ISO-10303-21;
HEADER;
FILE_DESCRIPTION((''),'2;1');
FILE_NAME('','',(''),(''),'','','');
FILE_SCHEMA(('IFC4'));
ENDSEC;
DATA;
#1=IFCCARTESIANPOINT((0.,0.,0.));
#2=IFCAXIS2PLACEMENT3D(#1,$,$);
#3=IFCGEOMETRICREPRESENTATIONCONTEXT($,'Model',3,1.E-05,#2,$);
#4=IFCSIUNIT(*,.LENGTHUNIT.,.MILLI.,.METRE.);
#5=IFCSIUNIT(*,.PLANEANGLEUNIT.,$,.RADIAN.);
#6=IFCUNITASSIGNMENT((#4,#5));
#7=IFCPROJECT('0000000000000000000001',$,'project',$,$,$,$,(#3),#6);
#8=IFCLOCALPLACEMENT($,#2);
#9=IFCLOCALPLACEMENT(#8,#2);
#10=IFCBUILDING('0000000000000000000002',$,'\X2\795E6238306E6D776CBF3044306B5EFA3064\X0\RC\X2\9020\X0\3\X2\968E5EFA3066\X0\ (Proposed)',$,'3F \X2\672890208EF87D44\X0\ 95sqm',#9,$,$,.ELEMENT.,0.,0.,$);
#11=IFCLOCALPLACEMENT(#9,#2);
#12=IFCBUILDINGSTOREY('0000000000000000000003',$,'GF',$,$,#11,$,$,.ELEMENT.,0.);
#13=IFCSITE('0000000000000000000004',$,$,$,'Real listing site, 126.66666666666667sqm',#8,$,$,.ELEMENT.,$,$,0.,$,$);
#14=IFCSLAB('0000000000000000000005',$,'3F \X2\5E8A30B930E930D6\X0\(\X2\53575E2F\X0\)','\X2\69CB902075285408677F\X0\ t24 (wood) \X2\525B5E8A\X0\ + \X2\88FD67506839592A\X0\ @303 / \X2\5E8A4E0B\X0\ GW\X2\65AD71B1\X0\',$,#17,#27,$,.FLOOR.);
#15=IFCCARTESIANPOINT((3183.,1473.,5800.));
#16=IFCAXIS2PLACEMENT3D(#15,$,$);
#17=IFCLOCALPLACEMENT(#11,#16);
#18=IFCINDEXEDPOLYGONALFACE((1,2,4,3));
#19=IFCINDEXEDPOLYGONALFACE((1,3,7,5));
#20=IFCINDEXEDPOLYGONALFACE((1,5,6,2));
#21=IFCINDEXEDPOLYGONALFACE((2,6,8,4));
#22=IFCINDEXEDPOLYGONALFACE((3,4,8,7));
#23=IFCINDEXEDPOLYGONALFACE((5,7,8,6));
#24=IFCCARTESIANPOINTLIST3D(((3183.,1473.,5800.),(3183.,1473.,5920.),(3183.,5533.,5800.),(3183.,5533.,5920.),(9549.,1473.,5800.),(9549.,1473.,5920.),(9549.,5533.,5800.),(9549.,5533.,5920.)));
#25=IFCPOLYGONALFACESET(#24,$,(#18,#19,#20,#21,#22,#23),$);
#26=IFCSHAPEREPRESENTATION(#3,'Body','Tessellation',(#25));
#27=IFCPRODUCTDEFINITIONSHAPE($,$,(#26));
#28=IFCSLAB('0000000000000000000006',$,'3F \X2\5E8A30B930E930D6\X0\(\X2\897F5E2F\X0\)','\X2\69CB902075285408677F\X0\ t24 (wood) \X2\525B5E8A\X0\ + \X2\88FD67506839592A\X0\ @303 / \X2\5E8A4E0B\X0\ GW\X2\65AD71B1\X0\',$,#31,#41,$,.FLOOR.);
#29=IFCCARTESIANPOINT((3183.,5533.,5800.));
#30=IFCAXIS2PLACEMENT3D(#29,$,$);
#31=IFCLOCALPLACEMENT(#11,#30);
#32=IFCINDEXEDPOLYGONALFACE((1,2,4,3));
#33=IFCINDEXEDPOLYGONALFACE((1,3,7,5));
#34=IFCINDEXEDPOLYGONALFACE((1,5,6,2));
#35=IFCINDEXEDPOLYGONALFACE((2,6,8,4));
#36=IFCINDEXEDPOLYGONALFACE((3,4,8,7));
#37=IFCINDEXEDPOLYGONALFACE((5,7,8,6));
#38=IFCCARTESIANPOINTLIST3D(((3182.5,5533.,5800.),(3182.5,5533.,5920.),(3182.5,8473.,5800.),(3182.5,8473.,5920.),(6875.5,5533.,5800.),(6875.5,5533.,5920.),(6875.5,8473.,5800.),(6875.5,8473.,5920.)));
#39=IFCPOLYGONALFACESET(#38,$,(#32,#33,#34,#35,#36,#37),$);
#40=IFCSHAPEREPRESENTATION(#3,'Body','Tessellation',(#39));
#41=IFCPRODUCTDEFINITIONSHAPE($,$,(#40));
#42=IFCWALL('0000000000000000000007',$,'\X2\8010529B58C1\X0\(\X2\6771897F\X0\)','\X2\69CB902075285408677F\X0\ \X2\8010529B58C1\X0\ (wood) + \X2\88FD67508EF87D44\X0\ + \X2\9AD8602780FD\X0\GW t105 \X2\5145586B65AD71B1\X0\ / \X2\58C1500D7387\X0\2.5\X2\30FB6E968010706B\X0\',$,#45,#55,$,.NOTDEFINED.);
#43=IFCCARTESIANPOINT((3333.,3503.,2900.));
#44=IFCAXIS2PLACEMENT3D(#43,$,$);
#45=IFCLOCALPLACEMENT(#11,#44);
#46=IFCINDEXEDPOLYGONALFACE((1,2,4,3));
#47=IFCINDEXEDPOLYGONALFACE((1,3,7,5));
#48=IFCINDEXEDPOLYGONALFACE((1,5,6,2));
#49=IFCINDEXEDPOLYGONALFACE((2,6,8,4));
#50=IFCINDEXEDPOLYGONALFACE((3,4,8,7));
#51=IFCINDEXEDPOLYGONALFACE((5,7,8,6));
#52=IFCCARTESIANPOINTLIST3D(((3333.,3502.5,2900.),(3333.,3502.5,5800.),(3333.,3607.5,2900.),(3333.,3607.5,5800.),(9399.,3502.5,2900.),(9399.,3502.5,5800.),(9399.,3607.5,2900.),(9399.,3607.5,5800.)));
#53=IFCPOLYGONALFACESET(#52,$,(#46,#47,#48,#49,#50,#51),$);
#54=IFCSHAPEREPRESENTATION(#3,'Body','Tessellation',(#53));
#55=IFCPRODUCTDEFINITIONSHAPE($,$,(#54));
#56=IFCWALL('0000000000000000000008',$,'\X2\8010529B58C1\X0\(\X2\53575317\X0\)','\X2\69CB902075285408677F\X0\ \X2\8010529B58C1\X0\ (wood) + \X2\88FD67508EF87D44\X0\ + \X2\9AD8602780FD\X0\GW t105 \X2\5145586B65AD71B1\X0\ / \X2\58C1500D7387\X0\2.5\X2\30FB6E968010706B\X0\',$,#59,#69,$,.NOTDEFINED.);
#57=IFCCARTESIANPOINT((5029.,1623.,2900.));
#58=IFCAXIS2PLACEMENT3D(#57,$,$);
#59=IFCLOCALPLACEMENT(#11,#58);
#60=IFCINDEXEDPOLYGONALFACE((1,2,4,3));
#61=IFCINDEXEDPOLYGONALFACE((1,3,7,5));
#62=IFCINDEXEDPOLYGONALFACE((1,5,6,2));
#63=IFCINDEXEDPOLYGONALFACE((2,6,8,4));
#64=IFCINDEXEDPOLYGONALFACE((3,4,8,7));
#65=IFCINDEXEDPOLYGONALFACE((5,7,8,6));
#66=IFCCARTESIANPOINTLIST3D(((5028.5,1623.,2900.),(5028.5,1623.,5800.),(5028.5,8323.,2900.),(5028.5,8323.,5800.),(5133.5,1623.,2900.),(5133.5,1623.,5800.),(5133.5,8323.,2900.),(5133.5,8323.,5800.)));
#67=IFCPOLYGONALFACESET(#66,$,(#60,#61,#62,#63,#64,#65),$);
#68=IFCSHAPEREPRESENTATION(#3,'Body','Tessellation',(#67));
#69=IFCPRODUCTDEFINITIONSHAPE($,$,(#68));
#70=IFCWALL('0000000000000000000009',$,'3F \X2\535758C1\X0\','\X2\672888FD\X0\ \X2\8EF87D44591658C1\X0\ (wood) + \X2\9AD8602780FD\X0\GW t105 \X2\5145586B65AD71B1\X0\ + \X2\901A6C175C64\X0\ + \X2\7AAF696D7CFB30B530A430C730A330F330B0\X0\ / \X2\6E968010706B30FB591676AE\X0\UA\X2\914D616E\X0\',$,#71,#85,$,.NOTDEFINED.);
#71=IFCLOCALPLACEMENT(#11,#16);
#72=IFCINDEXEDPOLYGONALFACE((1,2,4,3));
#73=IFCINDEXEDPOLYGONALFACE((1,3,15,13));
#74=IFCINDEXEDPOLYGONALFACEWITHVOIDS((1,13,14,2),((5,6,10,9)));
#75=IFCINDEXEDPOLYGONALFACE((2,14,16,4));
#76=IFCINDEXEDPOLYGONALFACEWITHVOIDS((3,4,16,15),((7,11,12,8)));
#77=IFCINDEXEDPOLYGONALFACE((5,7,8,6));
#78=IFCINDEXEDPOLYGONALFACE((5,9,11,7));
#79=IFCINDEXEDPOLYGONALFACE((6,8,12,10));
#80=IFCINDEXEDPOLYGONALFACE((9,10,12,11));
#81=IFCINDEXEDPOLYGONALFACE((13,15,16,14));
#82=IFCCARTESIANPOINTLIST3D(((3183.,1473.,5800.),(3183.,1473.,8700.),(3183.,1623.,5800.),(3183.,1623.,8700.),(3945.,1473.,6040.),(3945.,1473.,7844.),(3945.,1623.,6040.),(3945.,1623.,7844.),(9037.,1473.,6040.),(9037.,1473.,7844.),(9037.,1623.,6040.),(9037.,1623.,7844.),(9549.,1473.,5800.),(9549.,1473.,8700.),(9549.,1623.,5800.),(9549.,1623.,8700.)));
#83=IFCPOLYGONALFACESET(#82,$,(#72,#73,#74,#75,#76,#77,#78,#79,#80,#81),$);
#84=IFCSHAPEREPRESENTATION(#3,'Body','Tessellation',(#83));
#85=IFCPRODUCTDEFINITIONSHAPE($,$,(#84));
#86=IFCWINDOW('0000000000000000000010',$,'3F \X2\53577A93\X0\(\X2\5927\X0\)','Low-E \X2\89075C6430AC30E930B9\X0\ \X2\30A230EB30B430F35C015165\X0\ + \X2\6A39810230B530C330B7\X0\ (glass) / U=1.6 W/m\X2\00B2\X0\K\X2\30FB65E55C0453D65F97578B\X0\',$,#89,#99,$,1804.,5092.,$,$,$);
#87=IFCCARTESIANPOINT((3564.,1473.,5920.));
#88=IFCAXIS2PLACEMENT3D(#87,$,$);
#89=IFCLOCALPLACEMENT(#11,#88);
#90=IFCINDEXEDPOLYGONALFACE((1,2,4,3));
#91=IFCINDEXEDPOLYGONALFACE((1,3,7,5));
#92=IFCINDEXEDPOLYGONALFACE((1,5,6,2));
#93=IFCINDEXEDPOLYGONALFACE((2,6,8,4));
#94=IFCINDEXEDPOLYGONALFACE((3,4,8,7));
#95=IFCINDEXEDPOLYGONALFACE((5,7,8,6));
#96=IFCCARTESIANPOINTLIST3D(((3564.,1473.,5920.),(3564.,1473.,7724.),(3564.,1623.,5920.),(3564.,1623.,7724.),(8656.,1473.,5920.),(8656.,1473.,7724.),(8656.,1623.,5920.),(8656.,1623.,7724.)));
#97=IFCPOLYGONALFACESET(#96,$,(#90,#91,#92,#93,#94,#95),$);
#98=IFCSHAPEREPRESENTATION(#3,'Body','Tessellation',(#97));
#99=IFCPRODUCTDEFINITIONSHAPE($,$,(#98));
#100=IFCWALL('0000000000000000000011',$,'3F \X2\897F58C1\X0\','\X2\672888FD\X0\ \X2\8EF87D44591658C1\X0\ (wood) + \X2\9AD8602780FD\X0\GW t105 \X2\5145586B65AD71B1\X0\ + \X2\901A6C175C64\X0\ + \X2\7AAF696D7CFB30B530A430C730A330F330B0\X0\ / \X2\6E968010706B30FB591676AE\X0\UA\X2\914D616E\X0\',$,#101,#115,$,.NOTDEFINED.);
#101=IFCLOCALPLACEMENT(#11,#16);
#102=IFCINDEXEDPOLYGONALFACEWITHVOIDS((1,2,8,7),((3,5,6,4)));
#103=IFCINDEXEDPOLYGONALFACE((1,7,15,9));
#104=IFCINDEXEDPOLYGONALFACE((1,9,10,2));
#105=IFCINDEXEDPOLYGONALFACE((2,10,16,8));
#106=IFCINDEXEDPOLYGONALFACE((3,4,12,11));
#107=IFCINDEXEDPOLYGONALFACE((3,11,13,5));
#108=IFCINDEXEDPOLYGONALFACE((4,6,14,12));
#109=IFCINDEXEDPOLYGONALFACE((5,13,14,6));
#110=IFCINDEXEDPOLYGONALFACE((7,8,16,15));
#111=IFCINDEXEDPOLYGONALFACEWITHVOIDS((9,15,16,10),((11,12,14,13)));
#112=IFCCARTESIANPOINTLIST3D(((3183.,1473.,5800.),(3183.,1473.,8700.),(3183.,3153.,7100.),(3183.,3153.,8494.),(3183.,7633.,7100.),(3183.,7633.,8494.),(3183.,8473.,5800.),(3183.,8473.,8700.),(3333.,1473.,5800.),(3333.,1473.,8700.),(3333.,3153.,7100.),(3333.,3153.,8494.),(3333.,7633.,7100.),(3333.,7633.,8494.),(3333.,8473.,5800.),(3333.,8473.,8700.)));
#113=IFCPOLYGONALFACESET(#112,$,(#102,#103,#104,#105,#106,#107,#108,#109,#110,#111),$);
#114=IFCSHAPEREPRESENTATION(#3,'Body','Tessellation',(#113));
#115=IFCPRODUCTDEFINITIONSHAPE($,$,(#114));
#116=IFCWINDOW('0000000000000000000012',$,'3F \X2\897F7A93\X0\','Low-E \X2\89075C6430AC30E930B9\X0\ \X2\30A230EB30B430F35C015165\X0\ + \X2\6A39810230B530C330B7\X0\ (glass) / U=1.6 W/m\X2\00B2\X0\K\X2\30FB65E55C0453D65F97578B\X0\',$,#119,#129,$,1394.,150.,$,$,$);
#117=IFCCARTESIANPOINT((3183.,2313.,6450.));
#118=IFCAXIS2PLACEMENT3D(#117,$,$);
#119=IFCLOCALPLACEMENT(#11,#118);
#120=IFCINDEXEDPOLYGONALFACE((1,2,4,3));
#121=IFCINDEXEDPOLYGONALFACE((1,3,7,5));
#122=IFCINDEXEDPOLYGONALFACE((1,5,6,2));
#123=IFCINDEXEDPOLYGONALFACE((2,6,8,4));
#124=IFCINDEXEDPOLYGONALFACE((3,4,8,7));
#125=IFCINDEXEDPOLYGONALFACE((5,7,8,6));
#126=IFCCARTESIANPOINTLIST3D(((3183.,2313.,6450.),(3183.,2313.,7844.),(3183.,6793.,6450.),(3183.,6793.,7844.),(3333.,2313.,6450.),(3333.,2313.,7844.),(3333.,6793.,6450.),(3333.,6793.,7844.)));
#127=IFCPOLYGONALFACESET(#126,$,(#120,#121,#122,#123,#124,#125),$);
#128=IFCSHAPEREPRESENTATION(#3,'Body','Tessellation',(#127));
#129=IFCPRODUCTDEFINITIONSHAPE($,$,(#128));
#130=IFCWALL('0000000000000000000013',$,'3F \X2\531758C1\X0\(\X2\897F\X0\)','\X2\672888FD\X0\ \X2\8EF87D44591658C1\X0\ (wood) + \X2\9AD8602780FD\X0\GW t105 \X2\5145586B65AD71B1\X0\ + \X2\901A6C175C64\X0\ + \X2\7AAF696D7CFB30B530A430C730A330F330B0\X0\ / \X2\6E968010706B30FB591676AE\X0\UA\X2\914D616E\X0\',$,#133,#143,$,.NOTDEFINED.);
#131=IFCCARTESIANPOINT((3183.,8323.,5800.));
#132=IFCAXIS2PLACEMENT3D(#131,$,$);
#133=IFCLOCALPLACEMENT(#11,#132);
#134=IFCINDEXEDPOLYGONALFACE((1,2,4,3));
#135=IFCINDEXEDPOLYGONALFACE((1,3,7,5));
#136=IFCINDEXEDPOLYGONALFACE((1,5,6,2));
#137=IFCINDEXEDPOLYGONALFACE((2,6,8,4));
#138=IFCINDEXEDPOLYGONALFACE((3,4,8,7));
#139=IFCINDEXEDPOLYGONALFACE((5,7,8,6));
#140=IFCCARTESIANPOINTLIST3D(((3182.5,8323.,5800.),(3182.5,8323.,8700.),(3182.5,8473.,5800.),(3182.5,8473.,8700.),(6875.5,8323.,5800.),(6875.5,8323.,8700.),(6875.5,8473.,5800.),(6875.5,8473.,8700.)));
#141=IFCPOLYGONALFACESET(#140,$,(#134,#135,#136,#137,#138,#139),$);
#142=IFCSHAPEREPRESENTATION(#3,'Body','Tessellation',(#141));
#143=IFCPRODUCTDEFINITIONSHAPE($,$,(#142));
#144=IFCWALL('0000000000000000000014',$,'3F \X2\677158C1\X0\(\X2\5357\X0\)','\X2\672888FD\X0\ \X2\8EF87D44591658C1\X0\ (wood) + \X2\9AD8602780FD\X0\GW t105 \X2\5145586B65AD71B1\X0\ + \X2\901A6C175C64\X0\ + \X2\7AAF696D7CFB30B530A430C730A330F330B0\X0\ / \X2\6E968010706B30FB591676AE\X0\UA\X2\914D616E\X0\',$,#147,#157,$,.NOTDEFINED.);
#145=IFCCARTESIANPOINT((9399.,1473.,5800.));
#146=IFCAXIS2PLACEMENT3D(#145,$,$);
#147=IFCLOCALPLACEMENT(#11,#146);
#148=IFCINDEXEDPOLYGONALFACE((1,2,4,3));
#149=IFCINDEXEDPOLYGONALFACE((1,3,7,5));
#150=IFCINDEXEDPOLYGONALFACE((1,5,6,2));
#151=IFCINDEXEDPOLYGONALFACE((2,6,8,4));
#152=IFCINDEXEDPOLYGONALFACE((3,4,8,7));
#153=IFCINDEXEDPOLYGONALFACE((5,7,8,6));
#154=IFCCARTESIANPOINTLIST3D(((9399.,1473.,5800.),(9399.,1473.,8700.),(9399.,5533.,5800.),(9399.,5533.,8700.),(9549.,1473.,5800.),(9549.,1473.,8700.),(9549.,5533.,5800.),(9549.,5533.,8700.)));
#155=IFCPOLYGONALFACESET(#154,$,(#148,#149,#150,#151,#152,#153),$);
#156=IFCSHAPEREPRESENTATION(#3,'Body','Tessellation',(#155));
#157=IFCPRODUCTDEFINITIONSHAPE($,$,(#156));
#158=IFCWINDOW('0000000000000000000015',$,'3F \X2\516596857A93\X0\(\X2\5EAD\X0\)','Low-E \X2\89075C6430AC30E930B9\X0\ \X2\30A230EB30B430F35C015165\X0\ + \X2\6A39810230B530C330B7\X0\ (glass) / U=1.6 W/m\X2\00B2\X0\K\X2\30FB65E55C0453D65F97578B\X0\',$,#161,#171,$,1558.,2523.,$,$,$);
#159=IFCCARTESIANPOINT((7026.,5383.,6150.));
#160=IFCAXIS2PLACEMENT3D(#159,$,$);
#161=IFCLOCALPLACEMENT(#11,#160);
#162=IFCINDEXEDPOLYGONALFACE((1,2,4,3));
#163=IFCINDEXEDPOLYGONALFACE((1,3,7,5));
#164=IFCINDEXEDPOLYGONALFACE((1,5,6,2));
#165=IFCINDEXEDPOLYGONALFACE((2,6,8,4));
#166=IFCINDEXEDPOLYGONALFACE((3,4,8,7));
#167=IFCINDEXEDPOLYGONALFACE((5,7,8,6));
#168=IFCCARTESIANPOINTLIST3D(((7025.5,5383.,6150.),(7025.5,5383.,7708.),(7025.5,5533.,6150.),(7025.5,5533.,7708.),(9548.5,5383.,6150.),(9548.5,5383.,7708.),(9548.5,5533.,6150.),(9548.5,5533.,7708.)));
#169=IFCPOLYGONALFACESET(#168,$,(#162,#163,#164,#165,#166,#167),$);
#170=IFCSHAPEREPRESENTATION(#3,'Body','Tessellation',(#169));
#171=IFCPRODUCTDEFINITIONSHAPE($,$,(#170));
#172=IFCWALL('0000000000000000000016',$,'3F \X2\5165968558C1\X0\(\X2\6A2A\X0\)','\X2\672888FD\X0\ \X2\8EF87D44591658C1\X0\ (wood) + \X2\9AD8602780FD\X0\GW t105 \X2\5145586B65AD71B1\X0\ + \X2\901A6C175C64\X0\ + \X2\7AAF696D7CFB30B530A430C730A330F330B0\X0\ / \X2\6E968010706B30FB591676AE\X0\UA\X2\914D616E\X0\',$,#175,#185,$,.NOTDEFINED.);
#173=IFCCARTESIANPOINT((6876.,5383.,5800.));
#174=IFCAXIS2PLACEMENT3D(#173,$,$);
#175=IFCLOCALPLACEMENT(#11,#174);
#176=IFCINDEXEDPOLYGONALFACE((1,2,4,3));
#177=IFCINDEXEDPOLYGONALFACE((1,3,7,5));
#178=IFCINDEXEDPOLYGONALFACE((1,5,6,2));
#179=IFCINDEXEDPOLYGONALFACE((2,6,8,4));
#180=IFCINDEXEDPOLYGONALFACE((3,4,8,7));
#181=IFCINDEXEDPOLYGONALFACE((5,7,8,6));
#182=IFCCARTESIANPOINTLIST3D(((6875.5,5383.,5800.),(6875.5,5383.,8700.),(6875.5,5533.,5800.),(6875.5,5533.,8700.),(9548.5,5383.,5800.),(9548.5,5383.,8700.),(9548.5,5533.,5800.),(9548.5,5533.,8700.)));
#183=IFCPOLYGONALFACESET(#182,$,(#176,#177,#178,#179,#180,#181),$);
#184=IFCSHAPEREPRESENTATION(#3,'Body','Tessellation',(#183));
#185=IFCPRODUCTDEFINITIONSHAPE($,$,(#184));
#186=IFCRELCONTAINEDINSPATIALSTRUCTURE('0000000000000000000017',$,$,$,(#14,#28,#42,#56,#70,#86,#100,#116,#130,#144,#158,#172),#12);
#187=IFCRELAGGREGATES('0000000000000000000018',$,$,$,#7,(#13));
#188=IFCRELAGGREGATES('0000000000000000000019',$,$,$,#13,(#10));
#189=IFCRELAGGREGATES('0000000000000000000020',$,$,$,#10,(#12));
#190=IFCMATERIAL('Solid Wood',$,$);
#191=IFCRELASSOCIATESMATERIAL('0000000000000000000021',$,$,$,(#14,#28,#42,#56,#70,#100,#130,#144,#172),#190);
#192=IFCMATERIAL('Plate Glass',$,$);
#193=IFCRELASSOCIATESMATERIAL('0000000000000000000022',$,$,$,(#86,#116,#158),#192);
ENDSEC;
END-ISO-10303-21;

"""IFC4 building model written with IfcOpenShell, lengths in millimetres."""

from ifc_helpers import new_model, si_unit, frame, frame_2d, origin, place, context, project, spatial, rectangle, extrude, material, element, fill, save


model = new_model("IFC4")

# Units and contexts
model_context = context("Model", 3, precision=1e-05, world=origin())
ifc_project = project(units=[si_unit("LENGTHUNIT", "METRE", prefix="MILLI"), si_unit("PLANEANGLEUNIT", "RADIAN")], contexts=[model_context])

# Site, building, storey
site_placement = place(None, origin())
site = spatial("IfcSite", under=ifc_project, at=site_placement, ObjectType="Real listing site, 126.66666666666667sqm", CompositionType="ELEMENT", RefElevation=0.0)
building_placement = place(site_placement, origin())
building = spatial("IfcBuilding", under=site, at=building_placement, Name="神戸の海沿いに建つRC造3階建て (Proposed)", ObjectType="3F 木造軸組 95sqm", CompositionType="ELEMENT", ElevationOfRefHeight=0.0, ElevationOfTerrain=0.0)
storey_placement = place(building_placement, origin())
storey = spatial("IfcBuildingStorey", under=building, at=storey_placement, Name="GF", CompositionType="ELEMENT", Elevation=0.0)

# Slabs
ifc_material_1 = material(Name="Solid Wood")
slab_1_placement = place(storey_placement, frame((3183.0, 1473.0, 5800.0)))
element("IfcSlab", 1, at=slab_1_placement, inside=storey, material=ifc_material_1, Name="3F 床スラブ(南帯)", Description="構造用合板 t24 (wood) 剛床 + 製材根太 @303 / 床下 GW断熱", PredefinedType="FLOOR", context=model_context, shape_type="SweptSolid", body=[
    extrude(rectangle(XDim=6366.0, YDim=4060.0, at=frame_2d((3183.0, 2030.0))), frame((3183.0, 1473.0, 5800.0)), (0.0, 0.0, 1.0), 120.0),
])
slab_2_placement = place(storey_placement, frame((3183.0, 5533.0, 5800.0)))
element("IfcSlab", 2, at=slab_2_placement, inside=storey, material=ifc_material_1, Name="3F 床スラブ(西帯)", Description="構造用合板 t24 (wood) 剛床 + 製材根太 @303 / 床下 GW断熱", PredefinedType="FLOOR", context=model_context, shape_type="SweptSolid", body=[
    extrude(rectangle(XDim=3693.0, YDim=2940.0, at=frame_2d((1846.0, 1470.0))), frame((3183.0, 5533.0, 5800.0)), (0.0, 0.0, 1.0), 120.0),
])

# Walls
wall_1_placement = place(storey_placement, frame((3333.0, 3503.0, 2900.0)))
element("IfcWall", 3, at=wall_1_placement, inside=storey, material=ifc_material_1, Name="耐力壁(東西)", Description="構造用合板 耐力壁 (wood) + 製材軸組 + 高性能GW t105 充填断熱 / 壁倍率2.5・準耐火", PredefinedType="NOTDEFINED", context=model_context, shape_type="SweptSolid", body=[
    extrude(rectangle(XDim=6066.0, YDim=105.0, at=frame_2d((3033.0, 52.0))), frame((3333.0, 3503.0, 2900.0)), (0.0, 0.0, 1.0), 2900.0),
])
wall_2_placement = place(storey_placement, frame((5029.0, 1623.0, 2900.0)))
element("IfcWall", 4, at=wall_2_placement, inside=storey, material=ifc_material_1, Name="耐力壁(南北)", Description="構造用合板 耐力壁 (wood) + 製材軸組 + 高性能GW t105 充填断熱 / 壁倍率2.5・準耐火", PredefinedType="NOTDEFINED", context=model_context, shape_type="SweptSolid", body=[
    extrude(rectangle(XDim=105.0, YDim=6700.0, at=frame_2d((52.0, 3350.0))), frame((5029.0, 1623.0, 2900.0)), (0.0, 0.0, 1.0), 2900.0),
])

# Walls, openings, windows
wall_3_placement = place(storey_placement, frame((3183.0, 1473.0, 5800.0)))
wall_3 = element("IfcWall", 5, at=wall_3_placement, inside=storey, material=ifc_material_1, Name="3F 南壁", Description="木製 軸組外壁 (wood) + 高性能GW t105 充填断熱 + 通気層 + 窯業系サイディング / 準耐火・外皮UA配慮", PredefinedType="NOTDEFINED", context=model_context, shape_type="SweptSolid", body=[
    extrude(rectangle(XDim=6366.0, YDim=150.0, at=frame_2d((3183.0, 75.0))), frame((3183.0, 1473.0, 5800.0)), (0.0, 0.0, 1.0), 2900.0),
])
opening_1_placement = place(storey_placement, frame((3564.0, 1473.0, 5920.0)))
opening_1 = element("IfcOpeningElement", 6, at=opening_1_placement, cuts=wall_3, PredefinedType="NOTDEFINED", context=model_context, shape_type="SweptSolid", body=[
    extrude(rectangle(XDim=5092.0, YDim=150.0, at=frame_2d((2546.0, 75.0))), frame((3564.0, 1473.0, 5920.0)), (0.0, 0.0, 1.0), 1804.0),
])
ifc_material_2 = material(Name="Plate Glass")
window_1_placement = place(storey_placement, frame((3564.0, 1473.0, 5920.0)))
window_1 = element("IfcWindow", 7, at=window_1_placement, inside=storey, material=ifc_material_2, Name="3F 南窓(大)", Description="Low-E 複層ガラス アルゴン封入 + 樹脂サッシ (glass) / U=1.6 W/m²K・日射取得型", OverallHeight=1804.0, OverallWidth=5092.0, context=model_context, shape_type="SweptSolid", body=[
    extrude(rectangle(XDim=5092.0, YDim=150.0, at=frame_2d((2546.0, 75.0))), frame((3564.0, 1473.0, 5920.0)), (0.0, 0.0, 1.0), 1804.0),
])
fill(opening_1, window_1)
wall_4_placement = place(storey_placement, frame((3183.0, 1473.0, 5800.0)))
wall_4 = element("IfcWall", 8, at=wall_4_placement, inside=storey, material=ifc_material_1, Name="3F 西壁", Description="木製 軸組外壁 (wood) + 高性能GW t105 充填断熱 + 通気層 + 窯業系サイディング / 準耐火・外皮UA配慮", PredefinedType="NOTDEFINED", context=model_context, shape_type="SweptSolid", body=[
    extrude(rectangle(XDim=150.0, YDim=7000.0, at=frame_2d((75.0, 3500.0))), frame((3183.0, 1473.0, 5800.0)), (0.0, 0.0, 1.0), 2900.0),
])
opening_2_placement = place(storey_placement, frame((3183.0, 2313.0, 6450.0)))
opening_2 = element("IfcOpeningElement", 9, at=opening_2_placement, cuts=wall_4, PredefinedType="NOTDEFINED", context=model_context, shape_type="SweptSolid", body=[
    extrude(rectangle(XDim=150.0, YDim=4480.0, at=frame_2d((75.0, 2240.0))), frame((3183.0, 2313.0, 6450.0)), (0.0, 0.0, 1.0), 1394.0),
])
window_2_placement = place(storey_placement, frame((3183.0, 2313.0, 6450.0)))
window_2 = element("IfcWindow", 10, at=window_2_placement, inside=storey, material=ifc_material_2, Name="3F 西窓", Description="Low-E 複層ガラス アルゴン封入 + 樹脂サッシ (glass) / U=1.6 W/m²K・日射取得型", OverallHeight=1394.0, OverallWidth=150.0, context=model_context, shape_type="SweptSolid", body=[
    extrude(rectangle(XDim=150.0, YDim=4480.0, at=frame_2d((75.0, 2240.0))), frame((3183.0, 2313.0, 6450.0)), (0.0, 0.0, 1.0), 1394.0),
])
fill(opening_2, window_2)

# Wall
wall_5_placement = place(storey_placement, frame((3183.0, 8323.0, 5800.0)))
element("IfcWall", 11, at=wall_5_placement, inside=storey, material=ifc_material_1, Name="3F 北壁(西)", Description="木製 軸組外壁 (wood) + 高性能GW t105 充填断熱 + 通気層 + 窯業系サイディング / 準耐火・外皮UA配慮", PredefinedType="NOTDEFINED", context=model_context, shape_type="SweptSolid", body=[
    extrude(rectangle(XDim=3693.0, YDim=150.0, at=frame_2d((1846.0, 75.0))), frame((3183.0, 8323.0, 5800.0)), (0.0, 0.0, 1.0), 2900.0),
])

# Wall, opening, window
wall_6_placement = place(storey_placement, frame((9399.0, 1473.0, 5800.0)))
wall_6 = element("IfcWall", 12, at=wall_6_placement, inside=storey, material=ifc_material_1, Name="3F 東壁(南)", Description="木製 軸組外壁 (wood) + 高性能GW t105 充填断熱 + 通気層 + 窯業系サイディング / 準耐火・外皮UA配慮", PredefinedType="NOTDEFINED", context=model_context, shape_type="SweptSolid", body=[
    extrude(rectangle(XDim=150.0, YDim=4060.0, at=frame_2d((75.0, 2030.0))), frame((9399.0, 1473.0, 5800.0)), (0.0, 0.0, 1.0), 2900.0),
])
opening_3_placement = place(storey_placement, frame((7026.0, 5383.0, 6150.0)))
opening_3 = element("IfcOpeningElement", 13, at=opening_3_placement, cuts=wall_6, PredefinedType="NOTDEFINED", context=model_context, shape_type="SweptSolid", body=[
    extrude(rectangle(XDim=2523.0, YDim=150.0, at=frame_2d((1261.0, 75.0))), frame((7026.0, 5383.0, 6150.0)), (0.0, 0.0, 1.0), 1558.0),
])
window_3_placement = place(storey_placement, frame((7026.0, 5383.0, 6150.0)))
window_3 = element("IfcWindow", 14, at=window_3_placement, inside=storey, material=ifc_material_2, Name="3F 入隅窓(庭)", Description="Low-E 複層ガラス アルゴン封入 + 樹脂サッシ (glass) / U=1.6 W/m²K・日射取得型", OverallHeight=1558.0, OverallWidth=2523.0, context=model_context, shape_type="SweptSolid", body=[
    extrude(rectangle(XDim=2523.0, YDim=150.0, at=frame_2d((1261.0, 75.0))), frame((7026.0, 5383.0, 6150.0)), (0.0, 0.0, 1.0), 1558.0),
])
fill(opening_3, window_3)

# Wall
wall_7_placement = place(storey_placement, frame((6876.0, 5383.0, 5800.0)))
element("IfcWall", 15, at=wall_7_placement, inside=storey, material=ifc_material_1, Name="3F 入隅壁(横)", Description="木製 軸組外壁 (wood) + 高性能GW t105 充填断熱 + 通気層 + 窯業系サイディング / 準耐火・外皮UA配慮", PredefinedType="NOTDEFINED", context=model_context, shape_type="SweptSolid", body=[
    extrude(rectangle(XDim=2673.0, YDim=150.0, at=frame_2d((1336.0, 75.0))), frame((6876.0, 5383.0, 5800.0)), (0.0, 0.0, 1.0), 2900.0),
])

save(model, "model.ifc")
